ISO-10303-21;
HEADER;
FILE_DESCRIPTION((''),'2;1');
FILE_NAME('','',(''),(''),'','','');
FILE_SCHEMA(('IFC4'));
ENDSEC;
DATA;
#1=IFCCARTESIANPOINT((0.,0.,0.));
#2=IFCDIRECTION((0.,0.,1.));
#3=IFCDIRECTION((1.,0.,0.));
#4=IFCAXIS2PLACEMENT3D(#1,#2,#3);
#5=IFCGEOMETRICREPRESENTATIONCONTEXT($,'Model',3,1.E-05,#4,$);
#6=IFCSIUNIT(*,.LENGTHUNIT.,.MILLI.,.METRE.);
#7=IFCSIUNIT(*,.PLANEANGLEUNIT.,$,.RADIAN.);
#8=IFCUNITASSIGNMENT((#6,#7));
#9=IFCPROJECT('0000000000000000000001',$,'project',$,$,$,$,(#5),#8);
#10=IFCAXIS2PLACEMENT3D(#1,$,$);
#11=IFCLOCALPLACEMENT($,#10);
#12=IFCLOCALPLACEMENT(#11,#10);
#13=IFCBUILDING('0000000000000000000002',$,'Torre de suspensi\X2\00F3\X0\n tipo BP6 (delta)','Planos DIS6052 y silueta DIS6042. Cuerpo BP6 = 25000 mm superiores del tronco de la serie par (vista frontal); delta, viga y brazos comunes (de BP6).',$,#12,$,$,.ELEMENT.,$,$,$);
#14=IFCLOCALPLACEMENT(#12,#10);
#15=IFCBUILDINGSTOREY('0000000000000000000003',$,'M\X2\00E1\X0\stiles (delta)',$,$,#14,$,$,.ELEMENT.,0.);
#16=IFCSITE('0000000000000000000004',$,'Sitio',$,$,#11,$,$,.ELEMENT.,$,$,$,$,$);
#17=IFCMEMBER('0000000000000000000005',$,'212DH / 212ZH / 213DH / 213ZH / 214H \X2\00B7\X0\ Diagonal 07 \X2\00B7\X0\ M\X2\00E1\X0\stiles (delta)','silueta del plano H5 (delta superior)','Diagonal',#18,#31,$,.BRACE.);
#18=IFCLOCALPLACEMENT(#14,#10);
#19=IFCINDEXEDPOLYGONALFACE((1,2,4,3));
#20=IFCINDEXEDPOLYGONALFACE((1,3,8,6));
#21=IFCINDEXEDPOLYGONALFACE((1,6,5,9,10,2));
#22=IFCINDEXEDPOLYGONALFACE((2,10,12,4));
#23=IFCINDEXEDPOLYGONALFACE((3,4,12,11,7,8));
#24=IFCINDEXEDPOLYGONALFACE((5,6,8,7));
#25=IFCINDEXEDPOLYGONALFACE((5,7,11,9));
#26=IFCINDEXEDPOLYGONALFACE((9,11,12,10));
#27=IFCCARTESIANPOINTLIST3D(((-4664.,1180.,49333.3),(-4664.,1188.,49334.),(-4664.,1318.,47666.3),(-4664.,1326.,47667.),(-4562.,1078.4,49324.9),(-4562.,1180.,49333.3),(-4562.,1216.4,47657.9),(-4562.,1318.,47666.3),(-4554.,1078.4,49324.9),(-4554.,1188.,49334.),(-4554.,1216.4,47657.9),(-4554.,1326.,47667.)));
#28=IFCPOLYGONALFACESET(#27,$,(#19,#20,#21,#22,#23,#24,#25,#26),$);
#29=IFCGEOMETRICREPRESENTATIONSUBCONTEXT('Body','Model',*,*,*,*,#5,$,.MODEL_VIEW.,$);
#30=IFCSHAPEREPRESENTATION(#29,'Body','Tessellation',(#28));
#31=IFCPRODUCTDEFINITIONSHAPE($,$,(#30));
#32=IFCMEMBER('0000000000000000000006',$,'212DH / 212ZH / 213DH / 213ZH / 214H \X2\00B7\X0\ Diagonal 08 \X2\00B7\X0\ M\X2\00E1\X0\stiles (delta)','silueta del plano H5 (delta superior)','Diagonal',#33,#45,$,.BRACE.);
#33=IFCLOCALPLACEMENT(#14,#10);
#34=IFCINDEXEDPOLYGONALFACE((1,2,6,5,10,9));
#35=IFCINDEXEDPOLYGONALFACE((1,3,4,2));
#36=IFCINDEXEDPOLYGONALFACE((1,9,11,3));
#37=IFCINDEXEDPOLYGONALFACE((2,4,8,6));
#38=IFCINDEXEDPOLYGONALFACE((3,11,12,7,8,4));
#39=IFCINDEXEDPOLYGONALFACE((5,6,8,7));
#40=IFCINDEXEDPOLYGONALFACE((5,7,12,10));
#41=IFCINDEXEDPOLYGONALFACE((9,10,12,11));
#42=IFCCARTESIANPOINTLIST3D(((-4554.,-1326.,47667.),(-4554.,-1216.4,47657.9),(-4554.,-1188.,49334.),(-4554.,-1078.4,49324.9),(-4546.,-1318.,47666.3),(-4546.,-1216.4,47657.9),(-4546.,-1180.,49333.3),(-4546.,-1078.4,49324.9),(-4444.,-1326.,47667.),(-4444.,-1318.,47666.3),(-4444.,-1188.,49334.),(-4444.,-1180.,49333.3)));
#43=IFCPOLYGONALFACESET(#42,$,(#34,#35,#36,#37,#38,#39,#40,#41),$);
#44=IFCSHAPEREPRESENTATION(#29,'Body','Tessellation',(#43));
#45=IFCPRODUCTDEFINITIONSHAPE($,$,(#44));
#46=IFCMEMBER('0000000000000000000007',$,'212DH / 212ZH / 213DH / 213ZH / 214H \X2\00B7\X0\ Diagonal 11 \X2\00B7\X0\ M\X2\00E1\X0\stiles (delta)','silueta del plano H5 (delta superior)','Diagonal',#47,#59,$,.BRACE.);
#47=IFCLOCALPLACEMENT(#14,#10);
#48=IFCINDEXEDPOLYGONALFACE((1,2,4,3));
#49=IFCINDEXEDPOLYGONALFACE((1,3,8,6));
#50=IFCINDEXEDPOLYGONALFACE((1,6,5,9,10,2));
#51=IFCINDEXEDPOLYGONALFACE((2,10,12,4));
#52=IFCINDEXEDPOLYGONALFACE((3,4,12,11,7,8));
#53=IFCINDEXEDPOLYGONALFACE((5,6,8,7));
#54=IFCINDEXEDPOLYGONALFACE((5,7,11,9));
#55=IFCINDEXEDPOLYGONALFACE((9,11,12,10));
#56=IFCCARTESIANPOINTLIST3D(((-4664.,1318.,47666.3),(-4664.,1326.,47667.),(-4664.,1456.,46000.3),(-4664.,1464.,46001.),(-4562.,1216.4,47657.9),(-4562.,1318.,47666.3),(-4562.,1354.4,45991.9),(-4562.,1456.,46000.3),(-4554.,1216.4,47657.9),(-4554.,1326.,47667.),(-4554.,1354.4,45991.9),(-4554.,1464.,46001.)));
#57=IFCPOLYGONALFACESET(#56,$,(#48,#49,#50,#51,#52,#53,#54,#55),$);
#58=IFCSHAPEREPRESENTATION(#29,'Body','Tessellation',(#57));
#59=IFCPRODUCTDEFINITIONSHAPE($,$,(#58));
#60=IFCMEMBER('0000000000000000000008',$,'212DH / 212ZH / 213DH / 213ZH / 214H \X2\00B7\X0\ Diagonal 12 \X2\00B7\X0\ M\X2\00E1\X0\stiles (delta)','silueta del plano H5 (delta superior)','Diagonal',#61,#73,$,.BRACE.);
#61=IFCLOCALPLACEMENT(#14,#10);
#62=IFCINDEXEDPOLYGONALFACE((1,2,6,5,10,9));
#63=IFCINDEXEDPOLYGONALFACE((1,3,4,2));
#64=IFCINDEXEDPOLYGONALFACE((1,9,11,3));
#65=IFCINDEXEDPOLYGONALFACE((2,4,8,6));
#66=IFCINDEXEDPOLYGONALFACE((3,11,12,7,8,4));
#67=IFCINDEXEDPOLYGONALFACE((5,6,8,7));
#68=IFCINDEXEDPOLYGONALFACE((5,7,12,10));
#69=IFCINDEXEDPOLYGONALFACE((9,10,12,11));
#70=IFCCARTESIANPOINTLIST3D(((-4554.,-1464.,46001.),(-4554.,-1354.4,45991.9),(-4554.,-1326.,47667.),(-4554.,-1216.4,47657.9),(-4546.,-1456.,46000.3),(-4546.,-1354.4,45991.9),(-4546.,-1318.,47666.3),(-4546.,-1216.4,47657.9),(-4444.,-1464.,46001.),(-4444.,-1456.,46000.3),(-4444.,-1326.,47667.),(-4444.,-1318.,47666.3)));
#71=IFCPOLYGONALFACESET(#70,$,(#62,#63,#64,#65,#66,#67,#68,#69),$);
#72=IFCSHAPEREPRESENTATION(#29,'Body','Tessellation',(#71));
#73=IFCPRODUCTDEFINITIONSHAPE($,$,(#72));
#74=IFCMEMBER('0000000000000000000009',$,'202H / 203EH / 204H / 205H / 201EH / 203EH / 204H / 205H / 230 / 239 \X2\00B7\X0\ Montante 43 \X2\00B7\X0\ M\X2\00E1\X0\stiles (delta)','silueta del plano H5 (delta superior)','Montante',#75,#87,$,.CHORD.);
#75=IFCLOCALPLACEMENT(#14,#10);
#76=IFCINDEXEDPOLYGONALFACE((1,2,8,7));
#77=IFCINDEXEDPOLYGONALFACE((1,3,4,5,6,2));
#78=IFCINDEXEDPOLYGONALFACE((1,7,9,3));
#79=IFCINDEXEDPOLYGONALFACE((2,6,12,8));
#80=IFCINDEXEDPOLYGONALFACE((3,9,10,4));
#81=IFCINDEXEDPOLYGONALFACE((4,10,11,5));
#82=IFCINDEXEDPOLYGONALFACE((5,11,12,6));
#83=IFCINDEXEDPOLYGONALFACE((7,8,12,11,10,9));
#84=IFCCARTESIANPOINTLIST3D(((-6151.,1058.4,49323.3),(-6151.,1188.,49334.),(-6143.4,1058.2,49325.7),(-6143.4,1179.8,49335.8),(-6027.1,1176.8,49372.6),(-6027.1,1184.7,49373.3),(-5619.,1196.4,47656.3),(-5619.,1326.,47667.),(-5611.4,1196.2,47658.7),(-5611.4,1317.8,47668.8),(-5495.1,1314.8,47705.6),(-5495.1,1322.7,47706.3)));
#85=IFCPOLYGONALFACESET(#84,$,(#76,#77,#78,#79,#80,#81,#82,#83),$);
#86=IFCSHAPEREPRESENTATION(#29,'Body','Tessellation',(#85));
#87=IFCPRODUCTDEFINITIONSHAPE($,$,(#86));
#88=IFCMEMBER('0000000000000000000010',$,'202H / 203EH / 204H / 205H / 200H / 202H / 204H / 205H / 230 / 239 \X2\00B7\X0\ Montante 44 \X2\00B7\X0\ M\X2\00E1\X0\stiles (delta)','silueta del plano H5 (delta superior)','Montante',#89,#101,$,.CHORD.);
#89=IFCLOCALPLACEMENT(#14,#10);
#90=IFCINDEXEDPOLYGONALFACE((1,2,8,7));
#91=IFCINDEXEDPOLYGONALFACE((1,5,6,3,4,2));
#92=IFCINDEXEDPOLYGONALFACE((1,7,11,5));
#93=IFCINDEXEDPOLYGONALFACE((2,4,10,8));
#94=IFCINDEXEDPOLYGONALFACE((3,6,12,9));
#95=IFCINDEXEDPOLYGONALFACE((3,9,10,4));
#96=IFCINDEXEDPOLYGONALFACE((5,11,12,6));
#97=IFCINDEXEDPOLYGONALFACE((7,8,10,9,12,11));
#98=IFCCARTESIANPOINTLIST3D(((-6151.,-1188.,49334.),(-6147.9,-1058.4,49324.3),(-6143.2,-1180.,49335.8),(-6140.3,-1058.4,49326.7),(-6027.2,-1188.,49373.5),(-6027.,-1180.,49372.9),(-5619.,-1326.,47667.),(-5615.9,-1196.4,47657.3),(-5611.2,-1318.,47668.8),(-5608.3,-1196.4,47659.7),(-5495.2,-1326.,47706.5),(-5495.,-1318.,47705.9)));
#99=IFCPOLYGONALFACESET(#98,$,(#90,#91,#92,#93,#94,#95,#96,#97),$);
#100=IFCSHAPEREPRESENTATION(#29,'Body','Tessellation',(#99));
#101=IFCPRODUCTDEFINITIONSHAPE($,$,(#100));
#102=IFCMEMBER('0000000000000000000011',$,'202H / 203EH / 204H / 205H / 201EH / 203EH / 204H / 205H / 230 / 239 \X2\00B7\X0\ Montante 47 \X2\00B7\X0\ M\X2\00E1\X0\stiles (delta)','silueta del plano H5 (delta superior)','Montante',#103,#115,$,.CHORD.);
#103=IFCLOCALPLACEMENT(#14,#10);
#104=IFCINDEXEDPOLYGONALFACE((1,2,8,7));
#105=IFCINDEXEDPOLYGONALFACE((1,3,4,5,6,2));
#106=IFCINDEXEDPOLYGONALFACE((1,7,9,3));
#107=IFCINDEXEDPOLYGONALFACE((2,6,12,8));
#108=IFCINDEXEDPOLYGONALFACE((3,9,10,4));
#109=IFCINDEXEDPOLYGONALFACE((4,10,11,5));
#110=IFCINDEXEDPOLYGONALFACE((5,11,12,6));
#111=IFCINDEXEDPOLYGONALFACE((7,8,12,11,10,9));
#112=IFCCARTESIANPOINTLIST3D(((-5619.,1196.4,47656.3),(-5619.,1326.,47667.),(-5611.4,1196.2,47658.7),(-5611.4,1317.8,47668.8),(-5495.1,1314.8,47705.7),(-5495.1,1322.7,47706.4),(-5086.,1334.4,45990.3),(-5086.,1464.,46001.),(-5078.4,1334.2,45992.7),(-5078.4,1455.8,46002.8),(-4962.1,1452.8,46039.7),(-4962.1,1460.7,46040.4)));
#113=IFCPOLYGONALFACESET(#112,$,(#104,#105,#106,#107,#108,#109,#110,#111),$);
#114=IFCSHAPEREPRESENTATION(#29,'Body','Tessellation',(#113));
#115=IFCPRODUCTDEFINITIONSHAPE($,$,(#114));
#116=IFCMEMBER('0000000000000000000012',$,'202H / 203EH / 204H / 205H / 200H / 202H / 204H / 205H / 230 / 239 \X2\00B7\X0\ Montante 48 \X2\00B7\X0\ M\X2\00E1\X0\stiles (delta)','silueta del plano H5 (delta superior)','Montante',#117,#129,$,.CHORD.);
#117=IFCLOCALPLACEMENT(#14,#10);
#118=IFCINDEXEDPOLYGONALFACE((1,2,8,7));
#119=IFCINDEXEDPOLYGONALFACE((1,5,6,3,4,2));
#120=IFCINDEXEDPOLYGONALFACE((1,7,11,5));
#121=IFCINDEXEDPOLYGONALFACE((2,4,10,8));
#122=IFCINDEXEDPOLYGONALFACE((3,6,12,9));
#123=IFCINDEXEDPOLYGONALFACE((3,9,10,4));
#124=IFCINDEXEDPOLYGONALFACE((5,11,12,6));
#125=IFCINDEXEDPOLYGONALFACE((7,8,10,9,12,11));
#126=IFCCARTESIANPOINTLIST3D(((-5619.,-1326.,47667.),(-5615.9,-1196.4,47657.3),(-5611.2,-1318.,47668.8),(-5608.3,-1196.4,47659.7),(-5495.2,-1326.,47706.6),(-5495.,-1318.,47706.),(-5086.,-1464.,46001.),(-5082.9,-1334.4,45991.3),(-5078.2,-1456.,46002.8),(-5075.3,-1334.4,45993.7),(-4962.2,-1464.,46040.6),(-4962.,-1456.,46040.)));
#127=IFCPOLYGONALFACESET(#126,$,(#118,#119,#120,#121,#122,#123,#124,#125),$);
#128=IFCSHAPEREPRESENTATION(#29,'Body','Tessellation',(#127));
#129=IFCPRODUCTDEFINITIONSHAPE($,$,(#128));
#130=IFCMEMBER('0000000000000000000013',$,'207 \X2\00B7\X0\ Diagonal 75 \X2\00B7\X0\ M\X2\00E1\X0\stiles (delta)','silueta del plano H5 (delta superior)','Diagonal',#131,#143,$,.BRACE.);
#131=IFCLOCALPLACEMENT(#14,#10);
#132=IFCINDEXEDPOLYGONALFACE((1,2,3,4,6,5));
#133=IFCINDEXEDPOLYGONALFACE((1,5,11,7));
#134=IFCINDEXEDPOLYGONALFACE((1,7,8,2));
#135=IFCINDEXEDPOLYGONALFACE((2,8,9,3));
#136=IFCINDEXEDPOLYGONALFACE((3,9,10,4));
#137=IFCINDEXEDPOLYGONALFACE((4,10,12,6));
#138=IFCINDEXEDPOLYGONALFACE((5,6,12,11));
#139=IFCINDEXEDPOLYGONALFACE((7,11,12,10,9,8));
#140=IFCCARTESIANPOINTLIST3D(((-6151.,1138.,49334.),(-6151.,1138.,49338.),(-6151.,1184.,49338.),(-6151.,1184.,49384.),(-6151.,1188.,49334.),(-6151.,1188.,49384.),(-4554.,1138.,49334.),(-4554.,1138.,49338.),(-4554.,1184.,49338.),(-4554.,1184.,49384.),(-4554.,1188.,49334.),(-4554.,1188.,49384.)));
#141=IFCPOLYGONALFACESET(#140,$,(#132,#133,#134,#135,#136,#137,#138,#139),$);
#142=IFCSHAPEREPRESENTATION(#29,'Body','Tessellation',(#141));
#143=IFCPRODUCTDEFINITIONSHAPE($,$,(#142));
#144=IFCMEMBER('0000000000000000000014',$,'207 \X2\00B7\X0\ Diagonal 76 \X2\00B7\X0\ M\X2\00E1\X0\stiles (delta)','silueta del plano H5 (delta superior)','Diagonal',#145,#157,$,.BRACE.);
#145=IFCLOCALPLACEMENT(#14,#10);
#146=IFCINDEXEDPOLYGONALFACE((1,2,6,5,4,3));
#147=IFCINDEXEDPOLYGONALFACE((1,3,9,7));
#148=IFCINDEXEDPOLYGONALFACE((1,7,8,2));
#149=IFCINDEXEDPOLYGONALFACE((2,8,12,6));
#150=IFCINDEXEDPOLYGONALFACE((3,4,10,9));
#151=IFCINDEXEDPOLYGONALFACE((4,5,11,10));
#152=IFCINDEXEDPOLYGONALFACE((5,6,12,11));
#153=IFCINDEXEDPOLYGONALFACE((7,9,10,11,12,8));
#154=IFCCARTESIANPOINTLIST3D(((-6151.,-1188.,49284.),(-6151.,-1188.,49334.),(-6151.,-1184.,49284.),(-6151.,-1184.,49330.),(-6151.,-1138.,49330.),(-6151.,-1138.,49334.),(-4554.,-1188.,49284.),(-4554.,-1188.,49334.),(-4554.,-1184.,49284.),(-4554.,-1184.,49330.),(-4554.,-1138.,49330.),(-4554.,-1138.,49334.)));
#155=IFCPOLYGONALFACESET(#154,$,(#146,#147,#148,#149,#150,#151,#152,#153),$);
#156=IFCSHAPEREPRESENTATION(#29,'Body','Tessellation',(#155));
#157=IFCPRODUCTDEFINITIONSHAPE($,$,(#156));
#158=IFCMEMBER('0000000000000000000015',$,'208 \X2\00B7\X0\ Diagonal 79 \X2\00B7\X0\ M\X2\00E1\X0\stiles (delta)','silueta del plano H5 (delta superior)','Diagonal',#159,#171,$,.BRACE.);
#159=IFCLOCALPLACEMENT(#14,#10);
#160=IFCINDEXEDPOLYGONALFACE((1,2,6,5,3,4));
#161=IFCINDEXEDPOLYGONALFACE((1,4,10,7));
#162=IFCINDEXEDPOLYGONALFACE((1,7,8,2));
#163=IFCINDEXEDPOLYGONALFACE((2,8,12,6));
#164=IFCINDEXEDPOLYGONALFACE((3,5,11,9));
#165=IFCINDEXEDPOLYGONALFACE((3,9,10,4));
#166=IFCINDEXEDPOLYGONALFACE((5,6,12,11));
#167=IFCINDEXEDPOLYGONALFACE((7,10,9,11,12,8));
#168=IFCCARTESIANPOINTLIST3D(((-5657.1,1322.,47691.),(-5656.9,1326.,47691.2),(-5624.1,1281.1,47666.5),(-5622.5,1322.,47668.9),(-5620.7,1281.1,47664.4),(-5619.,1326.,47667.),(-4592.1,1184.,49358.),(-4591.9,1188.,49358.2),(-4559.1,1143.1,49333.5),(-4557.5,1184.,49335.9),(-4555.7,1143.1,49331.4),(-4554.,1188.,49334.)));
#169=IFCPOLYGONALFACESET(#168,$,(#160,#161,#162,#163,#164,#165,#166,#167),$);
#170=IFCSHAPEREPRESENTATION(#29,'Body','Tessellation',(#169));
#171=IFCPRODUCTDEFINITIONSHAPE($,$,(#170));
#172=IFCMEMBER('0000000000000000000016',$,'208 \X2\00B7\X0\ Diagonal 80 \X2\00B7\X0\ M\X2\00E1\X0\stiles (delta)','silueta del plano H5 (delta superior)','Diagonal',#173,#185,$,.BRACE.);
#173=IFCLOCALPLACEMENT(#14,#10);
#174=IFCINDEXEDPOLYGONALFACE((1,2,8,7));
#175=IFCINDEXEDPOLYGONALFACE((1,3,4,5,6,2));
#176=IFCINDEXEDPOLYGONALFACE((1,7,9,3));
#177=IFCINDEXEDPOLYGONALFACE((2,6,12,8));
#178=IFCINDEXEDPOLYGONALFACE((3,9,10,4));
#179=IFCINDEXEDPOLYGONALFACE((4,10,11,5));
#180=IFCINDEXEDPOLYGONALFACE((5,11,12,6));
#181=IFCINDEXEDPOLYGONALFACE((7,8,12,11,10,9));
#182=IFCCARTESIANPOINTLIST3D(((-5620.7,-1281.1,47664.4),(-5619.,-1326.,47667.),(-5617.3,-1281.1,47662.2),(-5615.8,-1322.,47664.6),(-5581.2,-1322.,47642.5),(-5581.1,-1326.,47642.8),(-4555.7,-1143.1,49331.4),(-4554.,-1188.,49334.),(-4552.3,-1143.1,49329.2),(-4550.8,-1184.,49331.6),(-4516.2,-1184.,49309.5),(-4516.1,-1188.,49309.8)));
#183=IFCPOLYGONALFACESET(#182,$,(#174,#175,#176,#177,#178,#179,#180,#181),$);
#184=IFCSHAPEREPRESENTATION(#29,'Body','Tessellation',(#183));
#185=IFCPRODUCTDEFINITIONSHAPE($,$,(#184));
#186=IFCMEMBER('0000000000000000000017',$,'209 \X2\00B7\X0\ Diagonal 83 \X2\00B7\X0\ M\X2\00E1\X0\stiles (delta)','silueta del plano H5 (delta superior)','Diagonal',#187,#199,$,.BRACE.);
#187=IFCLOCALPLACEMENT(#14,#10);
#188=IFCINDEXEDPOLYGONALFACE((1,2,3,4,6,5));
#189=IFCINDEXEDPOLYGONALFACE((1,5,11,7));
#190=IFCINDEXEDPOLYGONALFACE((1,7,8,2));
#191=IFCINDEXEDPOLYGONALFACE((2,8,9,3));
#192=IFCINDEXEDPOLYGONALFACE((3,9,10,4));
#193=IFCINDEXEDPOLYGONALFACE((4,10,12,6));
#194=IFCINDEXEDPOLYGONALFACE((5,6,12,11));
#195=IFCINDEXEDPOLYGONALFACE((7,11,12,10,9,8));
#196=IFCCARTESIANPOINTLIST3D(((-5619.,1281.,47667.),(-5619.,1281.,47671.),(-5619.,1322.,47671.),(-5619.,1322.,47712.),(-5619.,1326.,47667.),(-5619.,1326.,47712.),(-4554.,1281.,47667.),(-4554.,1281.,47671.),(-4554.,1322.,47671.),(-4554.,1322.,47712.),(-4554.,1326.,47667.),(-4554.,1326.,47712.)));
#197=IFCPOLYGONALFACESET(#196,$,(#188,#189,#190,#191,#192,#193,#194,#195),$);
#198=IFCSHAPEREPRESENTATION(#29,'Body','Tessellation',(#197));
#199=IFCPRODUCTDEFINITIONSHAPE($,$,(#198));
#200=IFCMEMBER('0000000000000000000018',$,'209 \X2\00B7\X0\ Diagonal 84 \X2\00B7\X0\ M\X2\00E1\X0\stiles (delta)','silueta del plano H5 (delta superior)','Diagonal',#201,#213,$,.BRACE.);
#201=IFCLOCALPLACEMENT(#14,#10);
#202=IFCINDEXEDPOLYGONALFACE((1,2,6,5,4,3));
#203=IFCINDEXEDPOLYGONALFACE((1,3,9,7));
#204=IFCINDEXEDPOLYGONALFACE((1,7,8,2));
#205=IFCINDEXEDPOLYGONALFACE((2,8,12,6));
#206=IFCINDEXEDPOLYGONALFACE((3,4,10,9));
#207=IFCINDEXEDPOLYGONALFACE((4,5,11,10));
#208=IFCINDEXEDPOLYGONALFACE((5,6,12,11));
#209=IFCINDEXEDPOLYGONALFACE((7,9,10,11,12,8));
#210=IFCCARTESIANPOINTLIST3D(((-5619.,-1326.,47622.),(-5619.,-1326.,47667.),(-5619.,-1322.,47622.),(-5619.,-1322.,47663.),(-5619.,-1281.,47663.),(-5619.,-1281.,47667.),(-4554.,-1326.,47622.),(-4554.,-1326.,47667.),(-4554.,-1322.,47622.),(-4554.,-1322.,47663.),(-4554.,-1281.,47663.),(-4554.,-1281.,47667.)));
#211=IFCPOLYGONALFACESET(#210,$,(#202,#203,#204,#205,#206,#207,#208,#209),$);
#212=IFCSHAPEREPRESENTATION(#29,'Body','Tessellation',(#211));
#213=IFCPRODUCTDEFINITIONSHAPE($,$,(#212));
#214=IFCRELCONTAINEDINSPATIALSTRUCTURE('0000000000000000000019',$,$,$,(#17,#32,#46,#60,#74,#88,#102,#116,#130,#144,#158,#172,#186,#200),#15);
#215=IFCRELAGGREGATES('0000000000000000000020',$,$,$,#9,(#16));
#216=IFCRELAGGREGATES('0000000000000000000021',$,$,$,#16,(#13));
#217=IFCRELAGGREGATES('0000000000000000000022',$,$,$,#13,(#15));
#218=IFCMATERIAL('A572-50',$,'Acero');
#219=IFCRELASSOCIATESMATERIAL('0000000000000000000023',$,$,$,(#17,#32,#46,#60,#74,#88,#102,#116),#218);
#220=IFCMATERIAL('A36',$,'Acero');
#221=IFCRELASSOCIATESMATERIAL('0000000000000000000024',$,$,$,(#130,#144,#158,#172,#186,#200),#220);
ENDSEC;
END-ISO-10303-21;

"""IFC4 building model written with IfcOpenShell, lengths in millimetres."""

from ifc_helpers import new_model, si_unit, frame, frame_2d, origin, origin_with_axes, place, context, subcontext, project, spatial, l_section, extrude, material, element, save


model = new_model("IFC4")

# Units and contexts
model_context = context("Model", 3, precision=1e-05, world=origin_with_axes())
body_context = subcontext(model_context, "Body", "Model", "MODEL_VIEW")
ifc_project = project(units=[si_unit("LENGTHUNIT", "METRE", prefix="MILLI"), si_unit("PLANEANGLEUNIT", "RADIAN")], contexts=[model_context])

# Site, building, storey
site_placement = place(None, origin())
site = spatial("IfcSite", under=ifc_project, at=site_placement, Name="Sitio", CompositionType="ELEMENT")
building_placement = place(site_placement, origin())
building = spatial("IfcBuilding", under=site, at=building_placement, Name="Torre de suspensión tipo BP6 (delta)", Description="Planos DIS6052 y silueta DIS6042. Cuerpo BP6 = 25000 mm superiores del tronco de la serie par (vista frontal); delta, viga y brazos comunes (de BP6).", CompositionType="ELEMENT")
storey_placement = place(building_placement, origin())
storey = spatial("IfcBuildingStorey", under=building, at=storey_placement, Name="Mástiles (delta)", CompositionType="ELEMENT", Elevation=0.0)

# Members
ifc_material_1 = material(Name="A572-50", Category="Acero")
for number, where, z_axis, x_axis, name in (
    (1, (-4554.0, 1188.0, 49334.0), (0.0, 0.082501, -0.996591), (0.0, -0.996591, -0.082501), "212DH / 212ZH / 213DH / 213ZH / 214H · Diagonal 07 · Mástiles (delta)"),
    (2, (-4554.0, -1188.0, 49334.0), (0.0, -0.082501, -0.996591), (0.0, 0.996591, -0.082501), "212DH / 212ZH / 213DH / 213ZH / 214H · Diagonal 08 · Mástiles (delta)"),
):
    element("IfcMember", number, at=place(storey_placement, frame(where, z_axis=z_axis, x_axis=x_axis)), inside=storey, material=ifc_material_1, Name=name, Description="silueta del plano H5 (delta superior)", ObjectType="Diagonal", PredefinedType="BRACE", context=body_context, shape_type="SweptSolid", body=[
        extrude(l_section(Depth=110.0, Width=110.0, Thickness=8.0, at=frame_2d((55.0, 55.0))), None, (0.0, 0.0, 1.0), 1672.7),
    ])
for number, where, z_axis, x_axis, name in (
    (3, (-4554.0, 1326.0, 47667.0), (0.0, 0.08255, -0.996587), (0.0, -0.996587, -0.08255), "212DH / 212ZH / 213DH / 213ZH / 214H · Diagonal 11 · Mástiles (delta)"),
    (4, (-4554.0, -1326.0, 47667.0), (0.0, -0.08255, -0.996587), (0.0, 0.996587, -0.08255), "212DH / 212ZH / 213DH / 213ZH / 214H · Diagonal 12 · Mástiles (delta)"),
):
    element("IfcMember", number, at=place(storey_placement, frame(where, z_axis=z_axis, x_axis=x_axis)), inside=storey, material=ifc_material_1, Name=name, Description="silueta del plano H5 (delta superior)", ObjectType="Diagonal", PredefinedType="BRACE", context=body_context, shape_type="SweptSolid", body=[
        extrude(l_section(Depth=110.0, Width=110.0, Thickness=8.0, at=frame_2d((55.0, 55.0))), None, (0.0, 0.0, 1.0), 1671.7),
    ])
for number, where, z_axis, x_axis, name in (
    (5, (-6151.0, 1188.0, 49334.0), (0.303088, 0.078621, -0.949714), (0.952963, -0.025005, 0.302055), "202H / 203EH / 204H / 205H / 201EH / 203EH / 204H / 205H / 230 / 239 · Montante 43 · Mástiles (delta)"),
    (6, (-6151.0, -1188.0, 49334.0), (0.303088, -0.078621, -0.949714), (0.023903, 0.996905, -0.074899), "202H / 203EH / 204H / 205H / 200H / 202H / 204H / 205H / 230 / 239 · Montante 44 · Mástiles (delta)"),
):
    element("IfcMember", number, at=place(storey_placement, frame(where, z_axis=z_axis, x_axis=x_axis)), inside=storey, material=ifc_material_1, Name=name, Description="silueta del plano H5 (delta superior)", ObjectType="Montante", PredefinedType="CHORD", context=body_context, shape_type="SweptSolid", body=[
        extrude(l_section(Depth=130.0, Width=130.0, Thickness=8.0, at=frame_2d((65.0, 65.0))), None, (0.0, 0.0, 1.0), 1755.3),
    ])
for number, where, z_axis, x_axis, name in (
    (7, (-5619.0, 1326.0, 47667.0), (0.30377, 0.07865, -0.949494), (0.952746, -0.025076, 0.302733), "202H / 203EH / 204H / 205H / 201EH / 203EH / 204H / 205H / 230 / 239 · Montante 47 · Mástiles (delta)"),
    (8, (-5619.0, -1326.0, 47667.0), (0.30377, -0.07865, -0.949494), (0.023966, 0.996902, -0.074909), "202H / 203EH / 204H / 205H / 200H / 202H / 204H / 205H / 230 / 239 · Montante 48 · Mástiles (delta)"),
):
    element("IfcMember", number, at=place(storey_placement, frame(where, z_axis=z_axis, x_axis=x_axis)), inside=storey, material=ifc_material_1, Name=name, Description="silueta del plano H5 (delta superior)", ObjectType="Montante", PredefinedType="CHORD", context=body_context, shape_type="SweptSolid", body=[
        extrude(l_section(Depth=130.0, Width=130.0, Thickness=8.0, at=frame_2d((65.0, 65.0))), None, (0.0, 0.0, 1.0), 1754.6),
    ])
ifc_material_2 = material(Name="A36", Category="Acero")
for number, where, z_axis, x_axis, name in (
    (9, (-4554.0, 1188.0, 49334.0), (-1.0, 0.0, 0.0), (0.0, -1.0, 0.0), "207 · Diagonal 75 · Mástiles (delta)"),
    (10, (-4554.0, -1188.0, 49334.0), (-1.0, 0.0, 0.0), (0.0, 1.0, 0.0), "207 · Diagonal 76 · Mástiles (delta)"),
):
    element("IfcMember", number, at=place(storey_placement, frame(where, z_axis=z_axis, x_axis=x_axis)), inside=storey, material=ifc_material_2, Name=name, Description="silueta del plano H5 (delta superior)", ObjectType="Diagonal", PredefinedType="BRACE", context=body_context, shape_type="SweptSolid", body=[
        extrude(l_section(Depth=50.0, Width=50.0, Thickness=4.0, at=frame_2d((25.0, 25.0))), None, (0.0, 0.0, 1.0), 1597.0),
    ])
for number, where, z_axis, x_axis, name in (
    (11, (-4554.0, 1188.0, 49334.0), (-0.537074, 0.069593, -0.840659), (-0.037467, -0.997575, -0.058646), "208 · Diagonal 79 · Mástiles (delta)"),
    (12, (-4554.0, -1188.0, 49334.0), (-0.537074, -0.069593, -0.840659), (-0.037467, 0.997575, -0.058646), "208 · Diagonal 80 · Mástiles (delta)"),
):
    element("IfcMember", number, at=place(storey_placement, frame(where, z_axis=z_axis, x_axis=x_axis)), inside=storey, material=ifc_material_2, Name=name, Description="silueta del plano H5 (delta superior)", ObjectType="Diagonal", PredefinedType="BRACE", context=body_context, shape_type="SweptSolid", body=[
        extrude(l_section(Depth=45.0, Width=45.0, Thickness=4.0, at=frame_2d((22.5, 22.5))), None, (0.0, 0.0, 1.0), 1983.0),
    ])
for number, where, z_axis, x_axis, name in (
    (13, (-4554.0, 1326.0, 47667.0), (-1.0, 0.0, 0.0), (0.0, -1.0, 0.0), "209 · Diagonal 83 · Mástiles (delta)"),
    (14, (-4554.0, -1326.0, 47667.0), (-1.0, 0.0, 0.0), (0.0, 1.0, 0.0), "209 · Diagonal 84 · Mástiles (delta)"),
):
    element("IfcMember", number, at=place(storey_placement, frame(where, z_axis=z_axis, x_axis=x_axis)), inside=storey, material=ifc_material_2, Name=name, Description="silueta del plano H5 (delta superior)", ObjectType="Diagonal", PredefinedType="BRACE", context=body_context, shape_type="SweptSolid", body=[
        extrude(l_section(Depth=45.0, Width=45.0, Thickness=4.0, at=frame_2d((22.5, 22.5))), None, (0.0, 0.0, 1.0), 1065.0),
    ])

save(model, "model.ifc")
